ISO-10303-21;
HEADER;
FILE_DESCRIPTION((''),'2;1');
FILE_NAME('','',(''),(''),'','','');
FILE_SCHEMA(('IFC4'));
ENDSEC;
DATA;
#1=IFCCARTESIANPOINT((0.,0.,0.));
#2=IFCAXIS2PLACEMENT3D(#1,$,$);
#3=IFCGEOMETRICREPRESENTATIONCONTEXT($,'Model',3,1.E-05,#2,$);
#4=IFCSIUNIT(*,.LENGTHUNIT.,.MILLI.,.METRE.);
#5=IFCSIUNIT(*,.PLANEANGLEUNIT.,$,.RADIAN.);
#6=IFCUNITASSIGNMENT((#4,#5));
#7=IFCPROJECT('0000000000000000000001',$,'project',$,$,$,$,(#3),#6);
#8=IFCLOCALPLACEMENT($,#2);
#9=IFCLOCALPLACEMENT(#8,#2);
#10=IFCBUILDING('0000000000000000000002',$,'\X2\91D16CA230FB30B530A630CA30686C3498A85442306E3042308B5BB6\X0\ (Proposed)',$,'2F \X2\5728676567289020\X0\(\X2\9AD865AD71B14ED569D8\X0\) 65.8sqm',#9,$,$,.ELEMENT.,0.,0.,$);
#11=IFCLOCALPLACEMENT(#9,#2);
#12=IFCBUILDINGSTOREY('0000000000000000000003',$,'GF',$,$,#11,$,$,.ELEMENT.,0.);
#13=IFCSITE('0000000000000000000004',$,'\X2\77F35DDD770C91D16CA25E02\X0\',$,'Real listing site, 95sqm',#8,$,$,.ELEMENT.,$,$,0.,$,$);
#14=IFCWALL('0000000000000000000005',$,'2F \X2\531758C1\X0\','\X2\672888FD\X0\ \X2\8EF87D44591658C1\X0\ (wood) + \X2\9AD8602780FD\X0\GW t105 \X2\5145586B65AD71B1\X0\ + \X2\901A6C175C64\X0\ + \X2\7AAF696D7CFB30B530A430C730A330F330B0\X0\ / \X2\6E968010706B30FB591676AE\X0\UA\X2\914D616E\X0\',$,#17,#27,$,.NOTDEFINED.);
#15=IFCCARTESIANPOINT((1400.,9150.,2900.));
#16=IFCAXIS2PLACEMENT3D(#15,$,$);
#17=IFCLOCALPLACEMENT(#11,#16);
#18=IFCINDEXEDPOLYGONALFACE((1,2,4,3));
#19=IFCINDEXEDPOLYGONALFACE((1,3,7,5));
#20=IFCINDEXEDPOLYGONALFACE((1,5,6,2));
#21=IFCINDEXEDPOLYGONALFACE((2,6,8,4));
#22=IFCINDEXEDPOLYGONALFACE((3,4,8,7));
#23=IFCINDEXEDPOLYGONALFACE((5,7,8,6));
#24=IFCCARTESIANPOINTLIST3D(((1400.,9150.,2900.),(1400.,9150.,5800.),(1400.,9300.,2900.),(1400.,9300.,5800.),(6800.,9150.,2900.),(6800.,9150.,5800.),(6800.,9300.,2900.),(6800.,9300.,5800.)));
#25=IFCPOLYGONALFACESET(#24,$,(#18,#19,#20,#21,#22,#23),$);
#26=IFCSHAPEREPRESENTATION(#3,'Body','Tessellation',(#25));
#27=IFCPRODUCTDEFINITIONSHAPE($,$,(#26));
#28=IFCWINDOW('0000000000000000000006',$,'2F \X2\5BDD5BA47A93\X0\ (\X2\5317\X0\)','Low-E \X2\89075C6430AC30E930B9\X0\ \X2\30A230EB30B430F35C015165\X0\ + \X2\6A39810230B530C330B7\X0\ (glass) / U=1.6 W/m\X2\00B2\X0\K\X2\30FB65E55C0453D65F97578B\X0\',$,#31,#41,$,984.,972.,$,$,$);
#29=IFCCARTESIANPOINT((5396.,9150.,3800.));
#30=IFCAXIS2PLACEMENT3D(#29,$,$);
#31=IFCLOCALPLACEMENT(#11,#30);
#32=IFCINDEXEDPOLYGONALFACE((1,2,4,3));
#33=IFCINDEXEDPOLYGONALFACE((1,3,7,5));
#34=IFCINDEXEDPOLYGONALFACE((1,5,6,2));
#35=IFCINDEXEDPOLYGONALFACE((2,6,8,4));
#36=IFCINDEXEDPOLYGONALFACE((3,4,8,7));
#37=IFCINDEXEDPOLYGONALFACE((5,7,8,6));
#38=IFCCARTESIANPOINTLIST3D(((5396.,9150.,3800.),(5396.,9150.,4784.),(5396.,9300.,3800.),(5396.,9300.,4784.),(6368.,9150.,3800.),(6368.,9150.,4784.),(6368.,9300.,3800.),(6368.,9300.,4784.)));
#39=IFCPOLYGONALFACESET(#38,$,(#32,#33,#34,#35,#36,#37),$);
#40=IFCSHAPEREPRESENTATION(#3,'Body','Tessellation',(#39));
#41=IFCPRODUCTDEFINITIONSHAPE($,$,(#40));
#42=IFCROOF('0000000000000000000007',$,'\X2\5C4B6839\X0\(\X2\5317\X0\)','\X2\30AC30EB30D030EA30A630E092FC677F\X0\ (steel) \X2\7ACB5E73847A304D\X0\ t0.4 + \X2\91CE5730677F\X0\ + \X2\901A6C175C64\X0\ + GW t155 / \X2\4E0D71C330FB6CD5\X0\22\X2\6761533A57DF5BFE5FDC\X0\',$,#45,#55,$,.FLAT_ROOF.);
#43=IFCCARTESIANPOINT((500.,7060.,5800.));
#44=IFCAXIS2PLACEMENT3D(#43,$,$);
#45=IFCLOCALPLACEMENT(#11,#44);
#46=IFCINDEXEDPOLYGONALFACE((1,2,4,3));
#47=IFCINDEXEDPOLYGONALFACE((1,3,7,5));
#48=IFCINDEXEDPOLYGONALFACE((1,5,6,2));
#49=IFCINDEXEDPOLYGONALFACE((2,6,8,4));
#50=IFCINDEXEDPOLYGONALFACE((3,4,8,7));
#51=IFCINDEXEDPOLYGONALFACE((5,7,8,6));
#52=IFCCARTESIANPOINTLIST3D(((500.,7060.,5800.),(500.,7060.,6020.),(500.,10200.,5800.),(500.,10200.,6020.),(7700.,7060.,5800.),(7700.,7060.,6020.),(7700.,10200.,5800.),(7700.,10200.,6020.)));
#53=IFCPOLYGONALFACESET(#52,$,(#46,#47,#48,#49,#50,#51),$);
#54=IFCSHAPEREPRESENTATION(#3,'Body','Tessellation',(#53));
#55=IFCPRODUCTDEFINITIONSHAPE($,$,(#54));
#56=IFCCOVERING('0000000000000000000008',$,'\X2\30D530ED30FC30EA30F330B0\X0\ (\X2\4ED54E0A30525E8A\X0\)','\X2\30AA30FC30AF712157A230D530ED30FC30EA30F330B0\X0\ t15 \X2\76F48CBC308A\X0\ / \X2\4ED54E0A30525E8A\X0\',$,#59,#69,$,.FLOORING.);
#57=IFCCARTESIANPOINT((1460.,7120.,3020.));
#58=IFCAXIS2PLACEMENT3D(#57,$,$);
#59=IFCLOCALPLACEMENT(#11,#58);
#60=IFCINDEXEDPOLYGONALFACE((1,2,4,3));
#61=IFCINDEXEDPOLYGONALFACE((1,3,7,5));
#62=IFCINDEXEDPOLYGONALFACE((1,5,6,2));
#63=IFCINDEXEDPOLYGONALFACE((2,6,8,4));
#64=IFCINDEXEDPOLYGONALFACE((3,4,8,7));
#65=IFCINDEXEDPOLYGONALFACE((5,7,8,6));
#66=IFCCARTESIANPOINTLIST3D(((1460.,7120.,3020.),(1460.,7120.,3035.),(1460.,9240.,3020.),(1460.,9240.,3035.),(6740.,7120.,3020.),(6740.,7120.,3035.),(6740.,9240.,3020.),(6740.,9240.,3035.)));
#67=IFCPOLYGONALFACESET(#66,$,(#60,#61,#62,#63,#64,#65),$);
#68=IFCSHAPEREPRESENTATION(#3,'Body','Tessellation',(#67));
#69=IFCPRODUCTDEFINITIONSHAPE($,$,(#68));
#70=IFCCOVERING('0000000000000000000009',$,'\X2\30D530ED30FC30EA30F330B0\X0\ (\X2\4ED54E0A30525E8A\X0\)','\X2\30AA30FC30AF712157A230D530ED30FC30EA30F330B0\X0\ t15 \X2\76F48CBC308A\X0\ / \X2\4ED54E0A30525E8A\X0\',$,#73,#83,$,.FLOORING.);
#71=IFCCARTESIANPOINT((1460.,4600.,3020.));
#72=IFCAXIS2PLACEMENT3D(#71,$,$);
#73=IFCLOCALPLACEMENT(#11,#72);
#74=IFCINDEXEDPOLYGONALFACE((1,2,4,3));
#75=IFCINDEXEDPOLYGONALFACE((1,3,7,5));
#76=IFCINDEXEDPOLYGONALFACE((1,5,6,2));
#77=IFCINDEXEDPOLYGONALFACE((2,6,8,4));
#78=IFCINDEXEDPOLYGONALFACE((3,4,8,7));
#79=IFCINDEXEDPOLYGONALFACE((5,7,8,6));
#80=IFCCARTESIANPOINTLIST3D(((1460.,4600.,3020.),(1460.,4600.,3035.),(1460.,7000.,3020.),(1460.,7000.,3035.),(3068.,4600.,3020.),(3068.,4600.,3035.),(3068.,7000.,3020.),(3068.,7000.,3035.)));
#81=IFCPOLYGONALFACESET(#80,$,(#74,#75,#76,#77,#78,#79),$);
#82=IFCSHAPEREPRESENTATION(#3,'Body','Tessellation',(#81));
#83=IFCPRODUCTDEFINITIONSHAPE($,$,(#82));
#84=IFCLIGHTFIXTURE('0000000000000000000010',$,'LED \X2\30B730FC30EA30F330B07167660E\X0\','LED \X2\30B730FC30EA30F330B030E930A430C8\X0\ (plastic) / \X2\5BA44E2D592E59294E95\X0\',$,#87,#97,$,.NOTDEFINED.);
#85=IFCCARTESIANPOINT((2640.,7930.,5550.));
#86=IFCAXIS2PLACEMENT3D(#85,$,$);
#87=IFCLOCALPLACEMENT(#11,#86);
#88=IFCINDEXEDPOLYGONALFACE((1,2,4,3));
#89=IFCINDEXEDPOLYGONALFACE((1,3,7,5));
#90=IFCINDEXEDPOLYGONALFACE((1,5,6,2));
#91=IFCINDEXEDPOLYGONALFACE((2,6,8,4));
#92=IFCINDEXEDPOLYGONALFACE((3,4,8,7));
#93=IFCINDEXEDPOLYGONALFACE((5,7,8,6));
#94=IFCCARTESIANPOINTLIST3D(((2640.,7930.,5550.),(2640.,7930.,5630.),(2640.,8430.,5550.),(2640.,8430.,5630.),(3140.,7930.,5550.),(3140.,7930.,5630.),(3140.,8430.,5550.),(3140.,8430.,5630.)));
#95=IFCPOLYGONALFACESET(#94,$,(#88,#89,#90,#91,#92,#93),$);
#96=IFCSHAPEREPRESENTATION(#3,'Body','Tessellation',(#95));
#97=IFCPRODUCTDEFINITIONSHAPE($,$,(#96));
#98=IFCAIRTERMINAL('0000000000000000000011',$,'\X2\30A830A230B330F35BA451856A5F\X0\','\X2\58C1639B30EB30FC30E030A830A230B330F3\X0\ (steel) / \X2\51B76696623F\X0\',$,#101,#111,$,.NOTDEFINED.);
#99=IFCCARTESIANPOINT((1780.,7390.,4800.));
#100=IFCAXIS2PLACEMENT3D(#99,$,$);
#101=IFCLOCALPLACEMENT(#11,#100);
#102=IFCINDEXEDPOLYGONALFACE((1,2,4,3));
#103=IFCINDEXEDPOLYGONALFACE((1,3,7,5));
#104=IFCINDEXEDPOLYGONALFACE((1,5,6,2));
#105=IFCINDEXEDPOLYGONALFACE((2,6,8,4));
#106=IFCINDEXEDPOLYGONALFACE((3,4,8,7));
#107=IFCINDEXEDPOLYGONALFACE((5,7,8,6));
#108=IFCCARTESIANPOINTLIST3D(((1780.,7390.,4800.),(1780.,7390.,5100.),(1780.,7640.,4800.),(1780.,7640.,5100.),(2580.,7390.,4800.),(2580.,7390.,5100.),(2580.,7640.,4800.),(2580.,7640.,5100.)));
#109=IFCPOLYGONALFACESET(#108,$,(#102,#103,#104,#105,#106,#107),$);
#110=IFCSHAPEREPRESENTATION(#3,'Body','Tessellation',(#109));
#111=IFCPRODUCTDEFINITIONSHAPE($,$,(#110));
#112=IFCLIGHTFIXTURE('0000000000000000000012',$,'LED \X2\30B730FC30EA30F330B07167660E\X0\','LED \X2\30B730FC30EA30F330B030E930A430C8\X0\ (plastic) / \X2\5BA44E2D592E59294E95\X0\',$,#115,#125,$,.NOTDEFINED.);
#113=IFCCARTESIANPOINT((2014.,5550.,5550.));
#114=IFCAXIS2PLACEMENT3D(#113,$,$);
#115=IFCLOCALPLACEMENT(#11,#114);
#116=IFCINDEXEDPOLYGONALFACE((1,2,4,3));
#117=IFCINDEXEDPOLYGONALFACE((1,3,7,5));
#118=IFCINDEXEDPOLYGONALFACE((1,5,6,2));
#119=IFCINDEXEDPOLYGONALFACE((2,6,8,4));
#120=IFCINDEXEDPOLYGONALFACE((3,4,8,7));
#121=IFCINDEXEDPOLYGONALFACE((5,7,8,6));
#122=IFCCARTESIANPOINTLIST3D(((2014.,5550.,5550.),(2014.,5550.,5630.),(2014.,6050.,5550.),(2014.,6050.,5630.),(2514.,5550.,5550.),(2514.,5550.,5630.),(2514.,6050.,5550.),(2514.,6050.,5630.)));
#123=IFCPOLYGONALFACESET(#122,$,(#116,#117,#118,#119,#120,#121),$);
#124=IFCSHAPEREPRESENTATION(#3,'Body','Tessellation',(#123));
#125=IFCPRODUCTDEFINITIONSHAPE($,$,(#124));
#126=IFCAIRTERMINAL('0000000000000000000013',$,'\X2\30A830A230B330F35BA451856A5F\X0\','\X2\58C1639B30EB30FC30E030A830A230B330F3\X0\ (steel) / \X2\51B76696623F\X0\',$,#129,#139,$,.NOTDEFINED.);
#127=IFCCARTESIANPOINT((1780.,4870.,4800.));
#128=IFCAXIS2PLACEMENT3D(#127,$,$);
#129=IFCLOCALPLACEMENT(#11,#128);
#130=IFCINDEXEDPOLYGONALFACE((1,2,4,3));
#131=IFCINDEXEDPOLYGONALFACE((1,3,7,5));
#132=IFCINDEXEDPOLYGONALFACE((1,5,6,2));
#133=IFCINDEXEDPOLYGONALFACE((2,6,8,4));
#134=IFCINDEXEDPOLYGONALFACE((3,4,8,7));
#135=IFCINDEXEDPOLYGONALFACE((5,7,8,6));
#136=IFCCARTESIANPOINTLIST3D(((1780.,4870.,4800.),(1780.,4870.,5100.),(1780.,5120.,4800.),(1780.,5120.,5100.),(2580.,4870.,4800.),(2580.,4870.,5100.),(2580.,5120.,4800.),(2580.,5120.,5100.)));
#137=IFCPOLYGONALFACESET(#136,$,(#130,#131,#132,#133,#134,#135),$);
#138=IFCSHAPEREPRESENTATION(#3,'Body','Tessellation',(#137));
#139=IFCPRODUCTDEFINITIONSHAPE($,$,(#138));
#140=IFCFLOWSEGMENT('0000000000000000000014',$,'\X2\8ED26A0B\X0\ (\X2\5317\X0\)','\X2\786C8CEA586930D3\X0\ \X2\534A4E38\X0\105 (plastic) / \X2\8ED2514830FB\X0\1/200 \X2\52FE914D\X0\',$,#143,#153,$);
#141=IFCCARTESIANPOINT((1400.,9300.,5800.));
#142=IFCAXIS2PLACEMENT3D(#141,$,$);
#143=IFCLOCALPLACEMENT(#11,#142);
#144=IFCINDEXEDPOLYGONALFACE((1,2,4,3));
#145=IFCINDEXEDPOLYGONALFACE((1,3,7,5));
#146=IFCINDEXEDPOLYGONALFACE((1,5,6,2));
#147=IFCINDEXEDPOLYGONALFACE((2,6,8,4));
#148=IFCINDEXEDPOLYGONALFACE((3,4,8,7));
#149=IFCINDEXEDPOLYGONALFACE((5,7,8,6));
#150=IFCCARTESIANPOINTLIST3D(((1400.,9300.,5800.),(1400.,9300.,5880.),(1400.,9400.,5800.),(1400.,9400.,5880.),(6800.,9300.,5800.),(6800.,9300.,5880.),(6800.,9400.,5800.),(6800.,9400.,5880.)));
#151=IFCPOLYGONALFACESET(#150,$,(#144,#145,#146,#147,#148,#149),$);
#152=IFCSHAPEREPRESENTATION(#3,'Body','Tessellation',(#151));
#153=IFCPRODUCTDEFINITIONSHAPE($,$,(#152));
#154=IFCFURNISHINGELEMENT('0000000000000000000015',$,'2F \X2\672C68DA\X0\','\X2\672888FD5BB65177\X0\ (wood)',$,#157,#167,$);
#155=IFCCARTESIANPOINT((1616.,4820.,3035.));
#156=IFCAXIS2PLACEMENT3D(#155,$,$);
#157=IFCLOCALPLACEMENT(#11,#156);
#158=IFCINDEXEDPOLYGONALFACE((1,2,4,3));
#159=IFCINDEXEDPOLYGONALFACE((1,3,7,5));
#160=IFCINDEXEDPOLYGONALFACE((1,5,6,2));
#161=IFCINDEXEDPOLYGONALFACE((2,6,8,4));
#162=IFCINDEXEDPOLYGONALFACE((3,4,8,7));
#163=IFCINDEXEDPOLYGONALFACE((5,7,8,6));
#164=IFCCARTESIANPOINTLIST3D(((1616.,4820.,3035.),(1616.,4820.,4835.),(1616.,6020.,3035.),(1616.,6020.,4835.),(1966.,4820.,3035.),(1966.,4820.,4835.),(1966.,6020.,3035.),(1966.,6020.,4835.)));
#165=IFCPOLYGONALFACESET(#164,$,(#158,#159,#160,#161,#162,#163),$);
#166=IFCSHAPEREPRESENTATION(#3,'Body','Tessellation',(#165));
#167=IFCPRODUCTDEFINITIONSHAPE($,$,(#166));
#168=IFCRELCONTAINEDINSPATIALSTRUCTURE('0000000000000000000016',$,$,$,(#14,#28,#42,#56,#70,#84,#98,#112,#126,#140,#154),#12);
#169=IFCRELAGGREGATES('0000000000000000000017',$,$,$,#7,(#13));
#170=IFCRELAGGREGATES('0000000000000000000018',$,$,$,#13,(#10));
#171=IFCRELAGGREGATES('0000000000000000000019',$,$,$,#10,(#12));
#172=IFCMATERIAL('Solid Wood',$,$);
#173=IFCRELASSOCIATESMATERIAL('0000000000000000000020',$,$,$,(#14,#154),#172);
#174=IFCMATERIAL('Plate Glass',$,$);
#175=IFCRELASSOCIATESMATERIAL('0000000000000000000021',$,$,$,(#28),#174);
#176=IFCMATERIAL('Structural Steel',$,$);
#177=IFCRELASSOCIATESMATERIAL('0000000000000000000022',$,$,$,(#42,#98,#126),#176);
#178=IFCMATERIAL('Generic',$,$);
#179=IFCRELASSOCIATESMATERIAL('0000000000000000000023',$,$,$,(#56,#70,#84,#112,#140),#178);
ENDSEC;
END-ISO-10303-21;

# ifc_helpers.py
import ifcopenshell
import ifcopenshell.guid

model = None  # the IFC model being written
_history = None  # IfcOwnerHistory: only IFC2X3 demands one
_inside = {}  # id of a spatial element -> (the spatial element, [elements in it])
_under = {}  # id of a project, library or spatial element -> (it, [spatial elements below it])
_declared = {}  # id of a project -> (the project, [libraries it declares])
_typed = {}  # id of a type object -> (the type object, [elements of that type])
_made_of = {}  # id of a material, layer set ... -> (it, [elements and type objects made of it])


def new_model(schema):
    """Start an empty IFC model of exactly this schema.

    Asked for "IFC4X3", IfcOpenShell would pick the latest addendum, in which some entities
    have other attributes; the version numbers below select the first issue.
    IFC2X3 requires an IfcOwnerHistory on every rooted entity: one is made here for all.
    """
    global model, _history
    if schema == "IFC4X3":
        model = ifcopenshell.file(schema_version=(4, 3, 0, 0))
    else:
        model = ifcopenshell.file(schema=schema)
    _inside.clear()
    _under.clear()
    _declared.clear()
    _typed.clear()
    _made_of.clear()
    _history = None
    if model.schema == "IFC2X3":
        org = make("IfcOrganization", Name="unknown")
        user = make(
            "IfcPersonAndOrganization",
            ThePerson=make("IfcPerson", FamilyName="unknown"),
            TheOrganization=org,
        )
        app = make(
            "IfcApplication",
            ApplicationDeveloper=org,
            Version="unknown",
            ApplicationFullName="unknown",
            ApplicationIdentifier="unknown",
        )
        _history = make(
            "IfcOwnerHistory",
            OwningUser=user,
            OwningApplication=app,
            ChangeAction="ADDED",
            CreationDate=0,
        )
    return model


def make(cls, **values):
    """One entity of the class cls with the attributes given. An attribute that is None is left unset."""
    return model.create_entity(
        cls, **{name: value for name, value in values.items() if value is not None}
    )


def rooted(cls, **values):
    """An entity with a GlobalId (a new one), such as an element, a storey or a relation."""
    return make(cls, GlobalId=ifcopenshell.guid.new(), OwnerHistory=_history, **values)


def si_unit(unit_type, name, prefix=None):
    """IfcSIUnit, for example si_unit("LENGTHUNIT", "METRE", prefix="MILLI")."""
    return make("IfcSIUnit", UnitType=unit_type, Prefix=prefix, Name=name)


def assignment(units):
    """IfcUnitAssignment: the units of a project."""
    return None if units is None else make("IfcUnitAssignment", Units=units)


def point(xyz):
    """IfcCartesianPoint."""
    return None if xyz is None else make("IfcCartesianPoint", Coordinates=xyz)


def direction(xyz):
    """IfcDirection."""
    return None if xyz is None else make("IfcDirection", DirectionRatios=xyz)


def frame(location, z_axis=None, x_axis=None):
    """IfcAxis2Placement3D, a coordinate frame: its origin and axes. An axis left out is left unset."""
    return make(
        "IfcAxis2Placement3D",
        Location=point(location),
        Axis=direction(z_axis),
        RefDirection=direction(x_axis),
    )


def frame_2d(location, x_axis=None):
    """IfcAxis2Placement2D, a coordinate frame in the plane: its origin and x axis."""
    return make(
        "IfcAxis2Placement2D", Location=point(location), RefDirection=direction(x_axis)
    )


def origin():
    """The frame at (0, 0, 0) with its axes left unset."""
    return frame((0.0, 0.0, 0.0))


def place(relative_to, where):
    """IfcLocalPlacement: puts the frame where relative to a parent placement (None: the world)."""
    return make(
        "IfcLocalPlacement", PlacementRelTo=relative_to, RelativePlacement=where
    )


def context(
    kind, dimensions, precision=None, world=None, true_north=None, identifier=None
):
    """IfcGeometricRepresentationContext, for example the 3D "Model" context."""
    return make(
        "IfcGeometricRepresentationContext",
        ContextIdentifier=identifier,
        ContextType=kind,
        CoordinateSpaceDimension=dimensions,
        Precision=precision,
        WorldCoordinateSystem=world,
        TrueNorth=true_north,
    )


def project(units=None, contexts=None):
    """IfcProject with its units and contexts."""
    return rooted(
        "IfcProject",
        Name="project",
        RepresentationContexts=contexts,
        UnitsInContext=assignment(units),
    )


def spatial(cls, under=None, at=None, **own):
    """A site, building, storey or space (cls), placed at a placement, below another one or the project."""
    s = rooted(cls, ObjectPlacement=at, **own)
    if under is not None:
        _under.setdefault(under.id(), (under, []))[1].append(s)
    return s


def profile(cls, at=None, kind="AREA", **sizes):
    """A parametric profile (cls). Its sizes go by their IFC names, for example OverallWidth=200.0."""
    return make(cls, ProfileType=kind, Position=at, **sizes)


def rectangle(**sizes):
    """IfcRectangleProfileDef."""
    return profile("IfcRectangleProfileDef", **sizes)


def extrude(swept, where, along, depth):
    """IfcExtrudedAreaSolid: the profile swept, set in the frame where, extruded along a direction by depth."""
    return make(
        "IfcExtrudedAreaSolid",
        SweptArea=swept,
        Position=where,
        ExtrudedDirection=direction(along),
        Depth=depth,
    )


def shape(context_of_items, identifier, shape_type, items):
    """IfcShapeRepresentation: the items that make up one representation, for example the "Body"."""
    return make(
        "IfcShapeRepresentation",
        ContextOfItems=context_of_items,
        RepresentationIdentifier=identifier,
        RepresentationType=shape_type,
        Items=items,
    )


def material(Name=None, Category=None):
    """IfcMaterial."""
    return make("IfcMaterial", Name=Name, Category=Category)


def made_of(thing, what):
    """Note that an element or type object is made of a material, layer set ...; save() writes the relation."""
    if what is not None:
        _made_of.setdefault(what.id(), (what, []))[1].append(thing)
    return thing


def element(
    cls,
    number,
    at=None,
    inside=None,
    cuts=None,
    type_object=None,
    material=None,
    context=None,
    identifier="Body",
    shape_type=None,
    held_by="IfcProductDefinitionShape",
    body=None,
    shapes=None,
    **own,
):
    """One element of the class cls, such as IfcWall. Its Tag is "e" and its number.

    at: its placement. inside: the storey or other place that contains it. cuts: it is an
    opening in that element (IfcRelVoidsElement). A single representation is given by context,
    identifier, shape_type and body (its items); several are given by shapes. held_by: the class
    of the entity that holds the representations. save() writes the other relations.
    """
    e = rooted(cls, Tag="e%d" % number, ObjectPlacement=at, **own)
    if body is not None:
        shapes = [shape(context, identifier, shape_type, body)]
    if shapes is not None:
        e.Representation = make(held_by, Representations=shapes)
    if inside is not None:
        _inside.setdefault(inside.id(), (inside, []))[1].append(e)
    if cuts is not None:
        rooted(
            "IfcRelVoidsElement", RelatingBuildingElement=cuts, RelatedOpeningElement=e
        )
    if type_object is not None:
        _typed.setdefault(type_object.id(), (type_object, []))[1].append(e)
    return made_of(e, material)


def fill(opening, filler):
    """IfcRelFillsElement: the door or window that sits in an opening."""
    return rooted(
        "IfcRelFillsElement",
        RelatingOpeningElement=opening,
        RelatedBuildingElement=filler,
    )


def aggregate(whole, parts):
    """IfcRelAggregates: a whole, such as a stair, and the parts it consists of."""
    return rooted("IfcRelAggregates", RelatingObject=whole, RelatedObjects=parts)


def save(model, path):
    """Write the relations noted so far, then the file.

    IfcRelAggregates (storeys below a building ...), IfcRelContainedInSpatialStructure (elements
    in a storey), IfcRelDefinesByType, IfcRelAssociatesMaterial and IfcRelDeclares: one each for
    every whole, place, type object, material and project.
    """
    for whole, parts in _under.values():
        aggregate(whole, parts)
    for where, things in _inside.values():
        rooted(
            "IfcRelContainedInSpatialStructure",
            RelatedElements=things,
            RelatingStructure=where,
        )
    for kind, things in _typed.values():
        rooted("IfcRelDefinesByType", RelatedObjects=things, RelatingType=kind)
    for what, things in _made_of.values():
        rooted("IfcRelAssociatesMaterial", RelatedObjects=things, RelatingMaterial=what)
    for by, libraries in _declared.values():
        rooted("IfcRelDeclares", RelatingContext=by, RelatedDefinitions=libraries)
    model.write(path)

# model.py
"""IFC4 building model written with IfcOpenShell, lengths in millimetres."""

from ifc_helpers import new_model, si_unit, frame, frame_2d, origin, place, context, project, spatial, rectangle, extrude, material, element, fill, save


model = new_model("IFC4")

# Units and contexts
model_context = context("Model", 3, precision=1e-05, world=origin())
ifc_project = project(units=[si_unit("LENGTHUNIT", "METRE", prefix="MILLI"), si_unit("PLANEANGLEUNIT", "RADIAN")], contexts=[model_context])

# Site, building, storey
site_placement = place(None, origin())
site = spatial("IfcSite", under=ifc_project, at=site_placement, Name="石川県金沢市", ObjectType="Real listing site, 95sqm", CompositionType="ELEMENT", RefElevation=0.0)
building_placement = place(site_placement, origin())
building = spatial("IfcBuilding", under=site, at=building_placement, Name="金沢・サウナと水風呂のある家 (Proposed)", ObjectType="2F 在来木造(高断熱仕様) 65.8sqm", CompositionType="ELEMENT", ElevationOfRefHeight=0.0, ElevationOfTerrain=0.0)
storey_placement = place(building_placement, origin())
storey = spatial("IfcBuildingStorey", under=building, at=storey_placement, Name="GF", CompositionType="ELEMENT", Elevation=0.0)

# Shared definitions
ifc_material_1 = material(Name="Solid Wood")

# Wall, opening, window
wall_placement = place(storey_placement, frame((1400.0, 9150.0, 2900.0)))
wall = element("IfcWall", 1, at=wall_placement, inside=storey, material=ifc_material_1, Name="2F 北壁", Description="木製 軸組外壁 (wood) + 高性能GW t105 充填断熱 + 通気層 + 窯業系サイディング / 準耐火・外皮UA配慮", PredefinedType="NOTDEFINED", context=model_context, shape_type="SweptSolid", body=[
    extrude(rectangle(XDim=5400.0, YDim=150.0, at=frame_2d((2700.0, 75.0))), frame((1400.0, 9150.0, 2900.0)), (0.0, 0.0, 1.0), 2900.0),
])
opening_placement = place(storey_placement, frame((5396.0, 9150.0, 3800.0)))
opening = element("IfcOpeningElement", 2, at=opening_placement, cuts=wall, PredefinedType="NOTDEFINED", context=model_context, shape_type="SweptSolid", body=[
    extrude(rectangle(XDim=972.0, YDim=150.0, at=frame_2d((486.0, 75.0))), frame((5396.0, 9150.0, 3800.0)), (0.0, 0.0, 1.0), 984.0),
])
ifc_material_2 = material(Name="Plate Glass")
window_placement = place(storey_placement, frame((5396.0, 9150.0, 3800.0)))
window = element("IfcWindow", 3, at=window_placement, inside=storey, material=ifc_material_2, Name="2F 寝室窓 (北)", Description="Low-E 複層ガラス アルゴン封入 + 樹脂サッシ (glass) / U=1.6 W/m²K・日射取得型", OverallHeight=984.0, OverallWidth=972.0, context=model_context, shape_type="SweptSolid", body=[
    extrude(rectangle(XDim=972.0, YDim=150.0, at=frame_2d((486.0, 75.0))), frame((5396.0, 9150.0, 3800.0)), (0.0, 0.0, 1.0), 984.0),
])
fill(opening, window)

# Roof
ifc_material_3 = material(Name="Structural Steel")
for number, where, name in (
    (4, (500.0, 7060.0, 5800.0), "屋根(北)"),
):
    element("IfcRoof", number, at=place(storey_placement, frame(where)), inside=storey, material=ifc_material_3, Name=name, Description="ガルバリウム鋼板 (steel) 立平葺き t0.4 + 野地板 + 通気層 + GW t155 / 不燃・法22条区域対応", PredefinedType="FLAT_ROOF", context=model_context, shape_type="SweptSolid", body=[
        extrude(rectangle(XDim=7200.0, YDim=3140.0, at=frame_2d((3600.0, 1570.0))), frame((500.0, 7060.0, 5800.0)), (0.0, 0.0, 1.0), 220.0),
    ])

# Coverings
ifc_material_4 = material(Name="Generic")
covering_1_placement = place(storey_placement, frame((1460.0, 7120.0, 3020.0)))
element("IfcCovering", 5, at=covering_1_placement, inside=storey, material=ifc_material_4, Name="フローリング (仕上げ床)", Description="オーク無垢フローリング t15 直貼り / 仕上げ床", PredefinedType="FLOORING", context=model_context, shape_type="SweptSolid", body=[
    extrude(rectangle(XDim=5280.0, YDim=2120.0, at=frame_2d((2640.0, 1060.0))), frame((1460.0, 7120.0, 3020.0)), (0.0, 0.0, 1.0), 15.0),
])
covering_2_placement = place(storey_placement, frame((1460.0, 4600.0, 3020.0)))
element("IfcCovering", 6, at=covering_2_placement, inside=storey, material=ifc_material_4, Name="フローリング (仕上げ床)", Description="オーク無垢フローリング t15 直貼り / 仕上げ床", PredefinedType="FLOORING", context=model_context, shape_type="SweptSolid", body=[
    extrude(rectangle(XDim=1608.0, YDim=2400.0, at=frame_2d((804.0, 1200.0))), frame((1460.0, 4600.0, 3020.0)), (0.0, 0.0, 1.0), 15.0),
])

# Light fixture
light_fixture_1_placement = place(storey_placement, frame((2640.0, 7930.0, 5550.0)))
element("IfcLightFixture", 7, at=light_fixture_1_placement, inside=storey, material=ifc_material_4, Name="LED シーリング照明", Description="LED シーリングライト (plastic) / 室中央天井", PredefinedType="NOTDEFINED", context=model_context, shape_type="SweptSolid", body=[
    extrude(rectangle(XDim=500.0, YDim=500.0, at=frame_2d((250.0, 250.0))), frame((2640.0, 7930.0, 5550.0)), (0.0, 0.0, 1.0), 80.0),
])

# Air terminal
air_terminal_1_placement = place(storey_placement, frame((1780.0, 7390.0, 4800.0)))
element("IfcAirTerminal", 8, at=air_terminal_1_placement, inside=storey, material=ifc_material_3, Name="エアコン室内機", Description="壁掛ルームエアコン (steel) / 冷暖房", PredefinedType="NOTDEFINED", context=model_context, shape_type="SweptSolid", body=[
    extrude(rectangle(XDim=800.0, YDim=250.0, at=frame_2d((400.0, 125.0))), frame((1780.0, 7390.0, 4800.0)), (0.0, 0.0, 1.0), 300.0),
])

# Light fixture
light_fixture_2_placement = place(storey_placement, frame((2014.0, 5550.0, 5550.0)))
element("IfcLightFixture", 9, at=light_fixture_2_placement, inside=storey, material=ifc_material_4, Name="LED シーリング照明", Description="LED シーリングライト (plastic) / 室中央天井", PredefinedType="NOTDEFINED", context=model_context, shape_type="SweptSolid", body=[
    extrude(rectangle(XDim=500.0, YDim=500.0, at=frame_2d((250.0, 250.0))), frame((2014.0, 5550.0, 5550.0)), (0.0, 0.0, 1.0), 80.0),
])

# Air terminal
air_terminal_2_placement = place(storey_placement, frame((1780.0, 4870.0, 4800.0)))
element("IfcAirTerminal", 10, at=air_terminal_2_placement, inside=storey, material=ifc_material_3, Name="エアコン室内機", Description="壁掛ルームエアコン (steel) / 冷暖房", PredefinedType="NOTDEFINED", context=model_context, shape_type="SweptSolid", body=[
    extrude(rectangle(XDim=800.0, YDim=250.0, at=frame_2d((400.0, 125.0))), frame((1780.0, 4870.0, 4800.0)), (0.0, 0.0, 1.0), 300.0),
])

# Flow segment
flow_segment_placement = place(storey_placement, frame((1400.0, 9300.0, 5800.0)))
element("IfcFlowSegment", 11, at=flow_segment_placement, inside=storey, material=ifc_material_4, Name="軒樋 (北)", Description="硬質塩ビ 半丸105 (plastic) / 軒先・1/200 勾配", context=model_context, shape_type="SweptSolid", body=[
    extrude(rectangle(XDim=5400.0, YDim=100.0, at=frame_2d((2700.0, 50.0))), frame((1400.0, 9300.0, 5800.0)), (0.0, 0.0, 1.0), 80.0),
])

# Furnishing element
furnishing_placement = place(storey_placement, frame((1616.0, 4820.0, 3035.0)))
element("IfcFurnishingElement", 12, at=furnishing_placement, inside=storey, material=ifc_material_1, Name="2F 本棚", Description="木製家具 (wood)", context=model_context, shape_type="SweptSolid", body=[
    extrude(rectangle(XDim=350.0, YDim=1200.0, at=frame_2d((175.0, 600.0))), frame((1616.0, 4820.0, 3035.0)), (0.0, 0.0, 1.0), 1800.0),
])

save(model, "model.ifc")
